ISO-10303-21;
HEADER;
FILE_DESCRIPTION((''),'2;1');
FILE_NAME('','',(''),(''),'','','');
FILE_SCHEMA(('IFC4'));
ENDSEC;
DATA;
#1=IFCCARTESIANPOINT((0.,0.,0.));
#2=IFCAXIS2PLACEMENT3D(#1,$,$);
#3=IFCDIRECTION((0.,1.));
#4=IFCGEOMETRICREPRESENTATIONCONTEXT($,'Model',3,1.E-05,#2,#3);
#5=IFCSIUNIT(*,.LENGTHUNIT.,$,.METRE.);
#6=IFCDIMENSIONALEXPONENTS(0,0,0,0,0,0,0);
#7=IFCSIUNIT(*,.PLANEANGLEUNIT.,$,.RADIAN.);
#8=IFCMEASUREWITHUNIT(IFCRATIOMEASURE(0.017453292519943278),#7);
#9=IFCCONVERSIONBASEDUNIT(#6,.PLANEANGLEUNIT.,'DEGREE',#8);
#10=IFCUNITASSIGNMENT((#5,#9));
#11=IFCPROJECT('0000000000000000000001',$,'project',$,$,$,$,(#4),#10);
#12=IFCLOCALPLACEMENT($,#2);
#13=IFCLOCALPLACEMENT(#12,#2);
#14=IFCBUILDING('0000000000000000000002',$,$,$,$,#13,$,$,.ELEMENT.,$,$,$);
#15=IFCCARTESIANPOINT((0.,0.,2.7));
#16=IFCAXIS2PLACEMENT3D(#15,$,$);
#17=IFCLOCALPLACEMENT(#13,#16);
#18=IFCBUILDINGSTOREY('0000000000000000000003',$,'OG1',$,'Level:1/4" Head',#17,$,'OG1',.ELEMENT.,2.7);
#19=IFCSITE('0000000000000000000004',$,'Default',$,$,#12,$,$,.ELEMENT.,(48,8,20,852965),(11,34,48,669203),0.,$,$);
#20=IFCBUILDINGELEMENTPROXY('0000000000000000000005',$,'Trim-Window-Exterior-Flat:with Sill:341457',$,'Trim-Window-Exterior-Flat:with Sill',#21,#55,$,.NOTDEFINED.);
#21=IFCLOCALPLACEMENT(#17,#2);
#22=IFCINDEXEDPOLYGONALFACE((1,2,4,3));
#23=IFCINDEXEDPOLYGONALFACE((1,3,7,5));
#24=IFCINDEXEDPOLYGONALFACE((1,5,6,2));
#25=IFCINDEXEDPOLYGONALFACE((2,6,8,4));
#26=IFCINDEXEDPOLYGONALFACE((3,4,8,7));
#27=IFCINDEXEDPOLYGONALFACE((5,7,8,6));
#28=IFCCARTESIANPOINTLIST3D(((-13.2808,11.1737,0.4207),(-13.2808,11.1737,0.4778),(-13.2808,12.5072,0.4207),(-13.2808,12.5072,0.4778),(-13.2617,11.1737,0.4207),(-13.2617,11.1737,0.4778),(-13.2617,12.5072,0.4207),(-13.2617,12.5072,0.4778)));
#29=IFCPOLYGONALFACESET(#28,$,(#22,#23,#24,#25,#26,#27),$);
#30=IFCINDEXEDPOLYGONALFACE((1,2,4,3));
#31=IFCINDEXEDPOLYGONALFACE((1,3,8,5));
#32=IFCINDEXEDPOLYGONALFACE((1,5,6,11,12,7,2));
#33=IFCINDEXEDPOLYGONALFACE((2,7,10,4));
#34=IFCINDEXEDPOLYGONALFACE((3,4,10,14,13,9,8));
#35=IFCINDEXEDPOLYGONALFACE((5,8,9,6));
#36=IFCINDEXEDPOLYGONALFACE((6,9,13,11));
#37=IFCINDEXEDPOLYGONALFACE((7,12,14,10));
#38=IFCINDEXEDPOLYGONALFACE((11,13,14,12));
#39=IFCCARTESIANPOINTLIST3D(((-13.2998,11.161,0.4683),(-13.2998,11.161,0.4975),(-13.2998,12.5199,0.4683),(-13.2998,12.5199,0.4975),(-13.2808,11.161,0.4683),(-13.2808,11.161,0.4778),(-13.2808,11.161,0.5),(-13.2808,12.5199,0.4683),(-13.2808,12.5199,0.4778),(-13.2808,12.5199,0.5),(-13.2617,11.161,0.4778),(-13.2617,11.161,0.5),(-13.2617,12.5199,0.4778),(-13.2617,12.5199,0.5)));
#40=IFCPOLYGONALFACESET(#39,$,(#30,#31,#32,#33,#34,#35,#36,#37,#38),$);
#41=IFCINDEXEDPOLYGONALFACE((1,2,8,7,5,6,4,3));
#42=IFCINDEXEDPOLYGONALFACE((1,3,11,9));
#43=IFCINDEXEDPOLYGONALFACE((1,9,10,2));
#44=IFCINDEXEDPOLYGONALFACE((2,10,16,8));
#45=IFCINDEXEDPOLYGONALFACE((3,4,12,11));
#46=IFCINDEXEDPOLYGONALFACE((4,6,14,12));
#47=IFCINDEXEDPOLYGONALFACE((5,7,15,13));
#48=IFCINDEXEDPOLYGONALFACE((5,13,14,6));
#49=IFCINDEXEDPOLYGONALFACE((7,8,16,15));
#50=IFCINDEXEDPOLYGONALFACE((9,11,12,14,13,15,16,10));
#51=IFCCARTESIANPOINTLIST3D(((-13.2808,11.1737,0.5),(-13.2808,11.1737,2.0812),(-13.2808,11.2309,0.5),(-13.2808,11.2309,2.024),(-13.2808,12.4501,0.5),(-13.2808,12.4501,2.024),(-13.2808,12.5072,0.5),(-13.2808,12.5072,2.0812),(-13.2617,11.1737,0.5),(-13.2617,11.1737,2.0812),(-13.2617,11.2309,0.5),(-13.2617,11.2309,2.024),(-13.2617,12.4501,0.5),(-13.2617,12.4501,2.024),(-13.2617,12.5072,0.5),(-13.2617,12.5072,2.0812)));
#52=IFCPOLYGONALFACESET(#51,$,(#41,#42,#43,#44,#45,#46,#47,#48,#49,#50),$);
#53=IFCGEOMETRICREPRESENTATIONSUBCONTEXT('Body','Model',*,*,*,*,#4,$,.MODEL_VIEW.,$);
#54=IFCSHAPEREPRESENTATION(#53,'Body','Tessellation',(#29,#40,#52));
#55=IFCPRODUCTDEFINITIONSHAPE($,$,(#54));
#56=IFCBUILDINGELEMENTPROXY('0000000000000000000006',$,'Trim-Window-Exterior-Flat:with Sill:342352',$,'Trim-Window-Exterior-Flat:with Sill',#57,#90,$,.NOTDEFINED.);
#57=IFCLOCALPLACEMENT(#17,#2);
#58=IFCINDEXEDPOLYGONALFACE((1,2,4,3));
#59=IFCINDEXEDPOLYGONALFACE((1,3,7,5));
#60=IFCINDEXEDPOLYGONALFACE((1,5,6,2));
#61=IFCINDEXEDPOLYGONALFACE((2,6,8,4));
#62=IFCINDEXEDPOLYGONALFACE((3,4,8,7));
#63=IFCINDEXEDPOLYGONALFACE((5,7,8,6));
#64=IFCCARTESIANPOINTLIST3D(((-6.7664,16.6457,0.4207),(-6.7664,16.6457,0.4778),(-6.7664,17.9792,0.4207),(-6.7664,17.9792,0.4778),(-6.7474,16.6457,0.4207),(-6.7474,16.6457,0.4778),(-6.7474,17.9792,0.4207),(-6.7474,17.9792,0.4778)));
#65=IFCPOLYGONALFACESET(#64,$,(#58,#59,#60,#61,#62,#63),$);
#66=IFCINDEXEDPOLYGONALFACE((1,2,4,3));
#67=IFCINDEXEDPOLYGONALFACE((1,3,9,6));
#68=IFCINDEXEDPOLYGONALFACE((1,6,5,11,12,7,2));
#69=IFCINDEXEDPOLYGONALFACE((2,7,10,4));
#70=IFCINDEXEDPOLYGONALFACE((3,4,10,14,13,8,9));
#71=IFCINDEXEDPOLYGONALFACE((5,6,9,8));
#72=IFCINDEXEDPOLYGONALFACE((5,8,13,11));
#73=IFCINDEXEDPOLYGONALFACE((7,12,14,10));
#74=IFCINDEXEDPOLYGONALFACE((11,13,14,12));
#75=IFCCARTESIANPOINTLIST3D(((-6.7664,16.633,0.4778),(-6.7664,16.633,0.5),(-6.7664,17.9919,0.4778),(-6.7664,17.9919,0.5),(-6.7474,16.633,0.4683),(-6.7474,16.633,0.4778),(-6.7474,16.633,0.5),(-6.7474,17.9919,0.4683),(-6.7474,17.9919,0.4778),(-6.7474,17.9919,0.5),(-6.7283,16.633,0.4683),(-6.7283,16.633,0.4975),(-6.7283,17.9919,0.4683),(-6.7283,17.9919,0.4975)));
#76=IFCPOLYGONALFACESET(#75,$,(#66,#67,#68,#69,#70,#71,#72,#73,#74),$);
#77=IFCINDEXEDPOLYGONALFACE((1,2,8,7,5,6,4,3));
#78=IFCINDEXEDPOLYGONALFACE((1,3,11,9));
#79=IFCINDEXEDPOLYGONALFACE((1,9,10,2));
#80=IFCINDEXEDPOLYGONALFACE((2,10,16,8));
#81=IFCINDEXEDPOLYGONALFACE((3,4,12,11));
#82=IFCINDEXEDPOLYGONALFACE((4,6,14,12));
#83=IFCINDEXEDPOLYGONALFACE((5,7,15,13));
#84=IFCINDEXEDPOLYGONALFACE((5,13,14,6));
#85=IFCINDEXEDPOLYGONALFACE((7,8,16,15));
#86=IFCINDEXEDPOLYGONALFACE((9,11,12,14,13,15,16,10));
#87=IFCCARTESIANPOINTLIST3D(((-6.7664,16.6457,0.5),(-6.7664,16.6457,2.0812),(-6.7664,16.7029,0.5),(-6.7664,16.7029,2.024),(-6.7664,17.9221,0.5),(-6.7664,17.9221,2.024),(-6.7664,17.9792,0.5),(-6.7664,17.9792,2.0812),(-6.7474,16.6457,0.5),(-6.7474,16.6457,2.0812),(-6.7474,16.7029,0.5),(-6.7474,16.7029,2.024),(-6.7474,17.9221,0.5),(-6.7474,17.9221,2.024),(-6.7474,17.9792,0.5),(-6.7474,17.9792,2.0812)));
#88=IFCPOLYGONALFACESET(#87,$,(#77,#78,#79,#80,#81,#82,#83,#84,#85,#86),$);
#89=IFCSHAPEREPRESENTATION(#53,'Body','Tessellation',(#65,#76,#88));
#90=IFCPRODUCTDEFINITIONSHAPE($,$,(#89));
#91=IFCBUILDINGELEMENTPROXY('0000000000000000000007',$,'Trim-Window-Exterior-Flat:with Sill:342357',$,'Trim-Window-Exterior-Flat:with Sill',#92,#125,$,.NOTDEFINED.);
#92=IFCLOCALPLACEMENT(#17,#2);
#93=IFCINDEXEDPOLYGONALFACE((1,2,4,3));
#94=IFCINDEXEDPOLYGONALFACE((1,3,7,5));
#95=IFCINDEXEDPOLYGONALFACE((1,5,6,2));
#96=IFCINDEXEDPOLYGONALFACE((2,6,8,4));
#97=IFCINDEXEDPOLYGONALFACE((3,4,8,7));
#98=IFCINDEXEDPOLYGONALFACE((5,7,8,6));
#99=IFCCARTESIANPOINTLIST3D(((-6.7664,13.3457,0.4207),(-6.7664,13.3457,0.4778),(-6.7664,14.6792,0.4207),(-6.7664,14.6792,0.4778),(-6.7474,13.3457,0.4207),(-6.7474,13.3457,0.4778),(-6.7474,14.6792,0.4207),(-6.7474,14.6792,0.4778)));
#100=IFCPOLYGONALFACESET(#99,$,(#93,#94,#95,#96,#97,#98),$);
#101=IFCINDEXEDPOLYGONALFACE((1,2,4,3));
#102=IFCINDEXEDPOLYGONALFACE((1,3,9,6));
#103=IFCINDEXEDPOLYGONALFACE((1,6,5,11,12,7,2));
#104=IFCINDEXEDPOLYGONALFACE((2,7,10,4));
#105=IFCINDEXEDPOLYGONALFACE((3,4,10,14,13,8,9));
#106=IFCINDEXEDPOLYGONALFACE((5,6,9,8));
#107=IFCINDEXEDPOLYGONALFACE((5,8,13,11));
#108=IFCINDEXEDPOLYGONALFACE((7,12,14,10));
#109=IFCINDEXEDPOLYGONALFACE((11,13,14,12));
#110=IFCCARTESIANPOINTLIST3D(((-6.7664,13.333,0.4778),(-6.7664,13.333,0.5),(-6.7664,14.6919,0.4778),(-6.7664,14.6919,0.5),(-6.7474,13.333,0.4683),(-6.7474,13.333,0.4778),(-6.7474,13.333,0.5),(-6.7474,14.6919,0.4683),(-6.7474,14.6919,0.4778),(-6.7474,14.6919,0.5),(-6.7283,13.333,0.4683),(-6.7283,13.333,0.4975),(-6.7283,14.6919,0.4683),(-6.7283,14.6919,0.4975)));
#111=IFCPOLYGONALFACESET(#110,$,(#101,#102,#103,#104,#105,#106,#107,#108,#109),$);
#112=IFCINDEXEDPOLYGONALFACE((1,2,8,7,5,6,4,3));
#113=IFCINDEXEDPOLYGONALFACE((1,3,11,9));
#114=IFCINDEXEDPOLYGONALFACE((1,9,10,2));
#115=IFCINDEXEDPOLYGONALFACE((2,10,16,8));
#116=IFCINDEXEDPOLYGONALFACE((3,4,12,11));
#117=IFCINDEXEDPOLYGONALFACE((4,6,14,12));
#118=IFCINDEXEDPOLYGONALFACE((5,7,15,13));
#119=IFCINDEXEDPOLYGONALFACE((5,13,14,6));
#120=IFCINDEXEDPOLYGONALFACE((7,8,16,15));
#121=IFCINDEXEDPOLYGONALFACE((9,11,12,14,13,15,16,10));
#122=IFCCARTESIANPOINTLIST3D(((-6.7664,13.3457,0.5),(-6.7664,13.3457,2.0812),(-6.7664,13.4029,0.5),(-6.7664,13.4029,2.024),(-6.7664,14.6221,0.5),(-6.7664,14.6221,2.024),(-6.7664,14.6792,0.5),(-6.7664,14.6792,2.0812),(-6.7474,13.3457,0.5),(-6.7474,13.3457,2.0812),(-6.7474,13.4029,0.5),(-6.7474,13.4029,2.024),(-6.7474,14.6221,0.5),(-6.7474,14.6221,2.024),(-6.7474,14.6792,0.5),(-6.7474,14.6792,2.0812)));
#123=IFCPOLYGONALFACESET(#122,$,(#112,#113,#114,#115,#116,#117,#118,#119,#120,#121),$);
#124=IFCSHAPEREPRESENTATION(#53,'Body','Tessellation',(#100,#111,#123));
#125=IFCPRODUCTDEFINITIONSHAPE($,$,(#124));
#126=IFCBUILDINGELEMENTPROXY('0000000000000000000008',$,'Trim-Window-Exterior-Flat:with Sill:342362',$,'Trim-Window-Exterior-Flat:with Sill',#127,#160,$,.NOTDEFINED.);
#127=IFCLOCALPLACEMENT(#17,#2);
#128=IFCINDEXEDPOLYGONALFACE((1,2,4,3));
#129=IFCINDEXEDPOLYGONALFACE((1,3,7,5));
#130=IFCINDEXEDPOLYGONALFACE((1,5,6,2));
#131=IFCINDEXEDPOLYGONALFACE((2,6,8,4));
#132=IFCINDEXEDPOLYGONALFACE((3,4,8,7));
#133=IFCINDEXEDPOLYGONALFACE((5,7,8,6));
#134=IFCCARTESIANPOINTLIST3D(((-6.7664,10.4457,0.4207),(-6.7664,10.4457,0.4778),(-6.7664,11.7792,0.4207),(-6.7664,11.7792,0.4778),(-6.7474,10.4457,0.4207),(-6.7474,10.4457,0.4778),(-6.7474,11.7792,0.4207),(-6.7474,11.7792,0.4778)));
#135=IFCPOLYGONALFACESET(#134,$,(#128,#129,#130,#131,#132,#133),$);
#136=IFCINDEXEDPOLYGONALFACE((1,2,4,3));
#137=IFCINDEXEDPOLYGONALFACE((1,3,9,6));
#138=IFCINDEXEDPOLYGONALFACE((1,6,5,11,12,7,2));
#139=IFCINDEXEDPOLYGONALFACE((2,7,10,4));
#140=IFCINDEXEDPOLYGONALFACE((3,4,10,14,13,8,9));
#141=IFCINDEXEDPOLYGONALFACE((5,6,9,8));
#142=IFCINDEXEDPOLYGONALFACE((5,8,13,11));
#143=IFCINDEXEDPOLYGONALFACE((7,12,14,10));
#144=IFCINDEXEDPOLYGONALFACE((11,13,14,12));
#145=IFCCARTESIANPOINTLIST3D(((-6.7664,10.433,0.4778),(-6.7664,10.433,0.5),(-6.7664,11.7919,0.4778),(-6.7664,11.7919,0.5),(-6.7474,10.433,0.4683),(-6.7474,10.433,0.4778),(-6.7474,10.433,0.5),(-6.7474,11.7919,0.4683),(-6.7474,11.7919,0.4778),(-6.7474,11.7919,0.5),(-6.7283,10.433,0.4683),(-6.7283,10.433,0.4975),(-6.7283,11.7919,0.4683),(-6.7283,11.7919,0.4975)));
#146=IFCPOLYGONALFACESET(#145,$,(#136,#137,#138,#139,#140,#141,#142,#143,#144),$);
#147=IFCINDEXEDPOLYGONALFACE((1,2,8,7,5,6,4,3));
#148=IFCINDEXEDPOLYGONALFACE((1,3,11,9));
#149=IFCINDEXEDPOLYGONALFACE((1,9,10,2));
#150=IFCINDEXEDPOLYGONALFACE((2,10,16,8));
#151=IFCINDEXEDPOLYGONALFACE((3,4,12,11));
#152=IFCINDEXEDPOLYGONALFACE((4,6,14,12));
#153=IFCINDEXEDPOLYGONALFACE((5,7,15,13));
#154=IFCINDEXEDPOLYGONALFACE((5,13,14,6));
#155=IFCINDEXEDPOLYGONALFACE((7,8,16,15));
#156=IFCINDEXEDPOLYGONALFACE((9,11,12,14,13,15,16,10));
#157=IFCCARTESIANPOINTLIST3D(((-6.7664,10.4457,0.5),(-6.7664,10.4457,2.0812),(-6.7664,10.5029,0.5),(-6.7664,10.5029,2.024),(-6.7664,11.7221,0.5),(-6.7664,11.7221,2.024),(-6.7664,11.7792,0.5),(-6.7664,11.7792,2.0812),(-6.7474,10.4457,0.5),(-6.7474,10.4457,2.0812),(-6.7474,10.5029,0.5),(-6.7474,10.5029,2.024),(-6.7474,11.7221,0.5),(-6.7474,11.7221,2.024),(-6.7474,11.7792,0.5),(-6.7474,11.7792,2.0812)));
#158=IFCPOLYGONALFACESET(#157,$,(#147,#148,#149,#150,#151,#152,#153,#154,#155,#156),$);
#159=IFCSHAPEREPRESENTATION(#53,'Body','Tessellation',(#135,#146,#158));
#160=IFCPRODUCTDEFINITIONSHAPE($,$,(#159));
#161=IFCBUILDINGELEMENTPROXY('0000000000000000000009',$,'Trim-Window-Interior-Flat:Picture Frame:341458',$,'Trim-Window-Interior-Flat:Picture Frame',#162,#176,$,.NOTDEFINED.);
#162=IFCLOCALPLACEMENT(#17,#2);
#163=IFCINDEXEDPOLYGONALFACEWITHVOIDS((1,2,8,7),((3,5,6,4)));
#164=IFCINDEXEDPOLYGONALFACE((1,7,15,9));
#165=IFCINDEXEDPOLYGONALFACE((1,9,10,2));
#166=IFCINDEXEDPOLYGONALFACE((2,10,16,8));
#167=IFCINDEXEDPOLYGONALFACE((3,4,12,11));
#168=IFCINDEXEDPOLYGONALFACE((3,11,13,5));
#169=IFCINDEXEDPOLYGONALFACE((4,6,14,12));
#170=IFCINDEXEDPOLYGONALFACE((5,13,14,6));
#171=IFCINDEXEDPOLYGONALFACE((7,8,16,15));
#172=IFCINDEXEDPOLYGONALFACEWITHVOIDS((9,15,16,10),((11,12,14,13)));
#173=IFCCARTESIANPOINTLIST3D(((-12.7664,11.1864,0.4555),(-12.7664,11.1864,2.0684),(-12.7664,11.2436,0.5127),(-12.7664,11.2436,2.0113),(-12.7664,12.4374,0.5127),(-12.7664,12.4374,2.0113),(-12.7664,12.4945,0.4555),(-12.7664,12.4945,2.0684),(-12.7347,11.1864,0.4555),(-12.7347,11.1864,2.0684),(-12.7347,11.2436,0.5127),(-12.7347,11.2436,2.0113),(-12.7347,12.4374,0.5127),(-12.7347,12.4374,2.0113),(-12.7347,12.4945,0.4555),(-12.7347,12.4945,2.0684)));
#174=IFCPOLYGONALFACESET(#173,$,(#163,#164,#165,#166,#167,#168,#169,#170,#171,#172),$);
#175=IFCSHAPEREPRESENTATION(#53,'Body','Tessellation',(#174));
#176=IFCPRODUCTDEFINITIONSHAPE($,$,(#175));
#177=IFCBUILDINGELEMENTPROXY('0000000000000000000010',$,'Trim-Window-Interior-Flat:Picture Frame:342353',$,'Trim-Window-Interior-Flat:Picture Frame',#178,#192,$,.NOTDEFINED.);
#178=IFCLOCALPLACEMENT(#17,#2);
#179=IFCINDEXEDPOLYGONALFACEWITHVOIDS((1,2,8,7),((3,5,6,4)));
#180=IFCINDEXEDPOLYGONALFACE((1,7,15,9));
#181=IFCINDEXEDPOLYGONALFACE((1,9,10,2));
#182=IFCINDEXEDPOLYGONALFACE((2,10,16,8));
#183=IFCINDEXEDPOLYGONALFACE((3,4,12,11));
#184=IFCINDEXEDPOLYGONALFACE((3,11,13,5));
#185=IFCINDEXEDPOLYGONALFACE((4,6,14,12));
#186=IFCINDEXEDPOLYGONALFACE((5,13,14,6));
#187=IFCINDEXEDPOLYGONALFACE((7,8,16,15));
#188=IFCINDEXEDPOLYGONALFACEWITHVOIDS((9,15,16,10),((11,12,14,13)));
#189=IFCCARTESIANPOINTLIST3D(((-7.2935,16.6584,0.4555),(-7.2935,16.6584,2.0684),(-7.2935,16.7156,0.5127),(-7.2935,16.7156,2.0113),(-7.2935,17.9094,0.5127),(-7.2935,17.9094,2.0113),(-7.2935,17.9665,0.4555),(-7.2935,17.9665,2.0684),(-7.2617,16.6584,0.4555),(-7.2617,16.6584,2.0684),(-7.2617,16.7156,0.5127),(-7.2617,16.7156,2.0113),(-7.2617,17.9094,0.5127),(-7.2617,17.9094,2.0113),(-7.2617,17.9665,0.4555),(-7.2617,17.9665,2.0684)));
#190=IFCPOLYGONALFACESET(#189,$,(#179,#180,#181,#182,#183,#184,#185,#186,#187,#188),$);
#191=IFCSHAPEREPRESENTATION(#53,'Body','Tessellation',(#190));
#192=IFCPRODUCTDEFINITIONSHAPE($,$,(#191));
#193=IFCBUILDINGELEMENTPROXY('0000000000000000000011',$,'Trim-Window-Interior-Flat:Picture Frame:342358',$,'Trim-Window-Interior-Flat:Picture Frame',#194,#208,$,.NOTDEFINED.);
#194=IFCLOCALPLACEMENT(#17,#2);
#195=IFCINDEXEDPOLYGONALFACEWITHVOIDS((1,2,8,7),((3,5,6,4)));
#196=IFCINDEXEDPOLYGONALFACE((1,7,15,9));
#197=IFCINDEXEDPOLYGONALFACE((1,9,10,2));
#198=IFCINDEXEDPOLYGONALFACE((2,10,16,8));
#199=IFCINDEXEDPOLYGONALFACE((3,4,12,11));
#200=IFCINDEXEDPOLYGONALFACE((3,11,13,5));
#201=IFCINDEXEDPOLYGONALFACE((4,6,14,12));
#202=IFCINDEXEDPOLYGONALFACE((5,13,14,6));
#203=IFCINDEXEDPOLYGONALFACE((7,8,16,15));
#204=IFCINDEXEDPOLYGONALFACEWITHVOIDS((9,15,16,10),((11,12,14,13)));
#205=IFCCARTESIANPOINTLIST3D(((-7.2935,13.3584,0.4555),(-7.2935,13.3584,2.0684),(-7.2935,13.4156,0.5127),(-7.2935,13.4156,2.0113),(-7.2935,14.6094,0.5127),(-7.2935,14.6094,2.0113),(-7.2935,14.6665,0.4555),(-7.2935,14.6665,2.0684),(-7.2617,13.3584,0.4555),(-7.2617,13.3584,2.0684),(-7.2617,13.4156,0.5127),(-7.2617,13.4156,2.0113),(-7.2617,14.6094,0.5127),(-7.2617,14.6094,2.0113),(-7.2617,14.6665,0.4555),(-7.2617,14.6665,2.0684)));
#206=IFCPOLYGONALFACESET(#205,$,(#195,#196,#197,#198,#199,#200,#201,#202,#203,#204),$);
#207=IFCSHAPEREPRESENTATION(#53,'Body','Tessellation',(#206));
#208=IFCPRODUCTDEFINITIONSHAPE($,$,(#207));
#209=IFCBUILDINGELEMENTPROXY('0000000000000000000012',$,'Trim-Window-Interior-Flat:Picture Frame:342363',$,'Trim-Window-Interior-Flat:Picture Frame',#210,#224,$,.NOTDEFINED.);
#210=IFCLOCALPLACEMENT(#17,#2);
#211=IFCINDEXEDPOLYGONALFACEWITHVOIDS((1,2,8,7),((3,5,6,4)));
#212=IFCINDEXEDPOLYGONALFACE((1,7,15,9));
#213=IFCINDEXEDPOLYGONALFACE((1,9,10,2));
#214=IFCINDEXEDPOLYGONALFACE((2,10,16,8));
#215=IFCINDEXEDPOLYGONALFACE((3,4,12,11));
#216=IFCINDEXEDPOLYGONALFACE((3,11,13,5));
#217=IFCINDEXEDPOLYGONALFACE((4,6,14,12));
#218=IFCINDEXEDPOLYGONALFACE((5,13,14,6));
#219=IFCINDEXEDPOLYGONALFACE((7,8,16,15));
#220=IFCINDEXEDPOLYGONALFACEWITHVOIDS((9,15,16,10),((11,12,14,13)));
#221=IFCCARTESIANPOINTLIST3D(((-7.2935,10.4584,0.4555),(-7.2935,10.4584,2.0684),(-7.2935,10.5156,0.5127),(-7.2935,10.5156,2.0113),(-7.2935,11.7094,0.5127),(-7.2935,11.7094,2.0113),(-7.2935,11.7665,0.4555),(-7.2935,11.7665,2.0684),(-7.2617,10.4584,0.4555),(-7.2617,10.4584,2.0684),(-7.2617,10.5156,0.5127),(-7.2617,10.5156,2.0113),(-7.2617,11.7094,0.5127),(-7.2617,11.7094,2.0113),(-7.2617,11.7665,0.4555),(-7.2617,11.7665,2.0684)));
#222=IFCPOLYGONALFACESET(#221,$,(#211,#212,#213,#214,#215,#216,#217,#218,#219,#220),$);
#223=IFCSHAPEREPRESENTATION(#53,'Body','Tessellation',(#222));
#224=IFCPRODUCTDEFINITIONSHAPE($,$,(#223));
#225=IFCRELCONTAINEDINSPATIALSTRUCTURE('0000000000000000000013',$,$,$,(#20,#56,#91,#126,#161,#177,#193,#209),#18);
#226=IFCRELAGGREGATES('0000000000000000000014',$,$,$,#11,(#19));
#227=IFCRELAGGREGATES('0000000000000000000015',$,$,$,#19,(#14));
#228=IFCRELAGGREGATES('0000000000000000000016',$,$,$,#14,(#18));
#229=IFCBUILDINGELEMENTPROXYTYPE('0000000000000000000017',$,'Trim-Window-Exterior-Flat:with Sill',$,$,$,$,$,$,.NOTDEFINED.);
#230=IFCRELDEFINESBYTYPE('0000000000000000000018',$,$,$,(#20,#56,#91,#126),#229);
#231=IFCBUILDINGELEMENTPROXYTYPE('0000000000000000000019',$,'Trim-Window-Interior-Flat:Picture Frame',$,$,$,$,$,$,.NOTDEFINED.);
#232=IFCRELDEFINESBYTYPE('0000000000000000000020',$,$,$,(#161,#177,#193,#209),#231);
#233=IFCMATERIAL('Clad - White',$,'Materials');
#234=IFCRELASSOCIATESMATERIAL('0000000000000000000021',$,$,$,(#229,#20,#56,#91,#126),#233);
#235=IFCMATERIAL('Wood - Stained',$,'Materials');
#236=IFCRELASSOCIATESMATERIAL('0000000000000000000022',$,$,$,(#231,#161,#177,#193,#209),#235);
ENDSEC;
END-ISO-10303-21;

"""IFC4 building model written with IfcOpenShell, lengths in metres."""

from ifc_helpers import new_model, entity, si_unit, converted_unit, direction, frame, origin, place, context, subcontext, project, spatial, indexed_curve, outline, extrude, source, transform, mapped, material, type_object, type_shapes, element, save


model = new_model("IFC4")

# Units and contexts
model_context = context("Model", 3, precision=1e-05, world=origin(), true_north=direction((0.0, 1.0)))
body_context = subcontext(model_context, "Body", "Model", "MODEL_VIEW")
ifc_project = project(units=[si_unit("LENGTHUNIT", "METRE"), converted_unit("PLANEANGLEUNIT", "DEGREE", entity("IfcRatioMeasure", 0.017453292519943278), si_unit("PLANEANGLEUNIT", "RADIAN"), dimensions=[0, 0, 0, 0, 0, 0, 0])], contexts=[model_context])

# Site, building, storey
site_placement = place(None, origin())
site = spatial("IfcSite", under=ifc_project, at=site_placement, Name="Default", CompositionType="ELEMENT", RefLatitude=(48, 8, 20, 852965), RefLongitude=(11, 34, 48, 669203), RefElevation=0.0)
building_placement = place(site_placement, origin())
building = spatial("IfcBuilding", under=site, at=building_placement, CompositionType="ELEMENT")
storey_placement = place(building_placement, frame((0.0, 0.0, 2.7)))
storey = spatial("IfcBuildingStorey", under=building, at=storey_placement, Name="OG1", ObjectType="Level:1/4\" Head", LongName="OG1", CompositionType="ELEMENT", Elevation=2.7)

# Building element proxies
ifc_material_1 = material(Name="Clad - White", Category="Materials")
ifc_material_2 = material(Name="Wood - Stained", Category="Materials")
building_element_proxy_type_1 = type_object("IfcBuildingElementProxyType", Name="Trim-Window-Exterior-Flat:with Sill", PredefinedType="NOTDEFINED", material=ifc_material_1)
shared_shape_1 = source(origin(), body_context, "Body", "SweptSolid", [
    extrude(outline(indexed_curve([(-0.6667, -0.0286), (0.6667, -0.0286), (0.6667, 0.0286), (-0.6667, 0.0286), (-0.6667, -0.0286)], self_intersect=False)), frame((0.0, -1.5748, 0.0), z_axis=(0.0, 0.0, 1.0), x_axis=(-1.0, 0.0, 0.0)), (0.0, 0.0, 1.0), 0.019),
    extrude(outline(indexed_curve([(-0.019, -0.016), (0.0, -0.016), (0.0, -0.0064), (0.019, -0.0064), (0.019, 0.0158), (0.0, 0.0158), (-0.019, 0.0133), (-0.019, -0.016)], self_intersect=False)), frame((-0.6794, -1.5398, 0.019), z_axis=(1.0, 0.0, 0.0), x_axis=(0.0, 0.0, -1.0)), (0.0, 0.0, 1.0), 1.3589),
    extrude(outline(indexed_curve([(-0.8049, -0.6667), (0.7763, -0.6667), (0.7763, -0.6096), (-0.7477, -0.6096), (-0.7477, 0.6096), (0.7763, 0.6096), (0.7763, 0.6667), (-0.8049, 0.6667), (-0.8049, -0.6667)], self_intersect=False)), frame((0.0, -0.7477, 0.0), z_axis=(0.0, 0.0, 1.0), x_axis=(0.0, -1.0, 0.0)), (0.0, 0.0, 1.0), 0.019),
])
type_shapes(building_element_proxy_type_1, [shared_shape_1])
for number, where, z_axis, x_axis, name in (
    (1, (-13.2617, 11.8405, 2.024), (-1.0, 0.0, 0.0), (0.0, -1.0, 0.0), "Trim-Window-Exterior-Flat:with Sill:341457"),
    (2, (-6.7664, 17.3125, 2.024), (1.0, 0.0, 0.0), (0.0, 1.0, 0.0), "Trim-Window-Exterior-Flat:with Sill:342352"),
    (3, (-6.7664, 14.0125, 2.024), (1.0, 0.0, 0.0), (0.0, 1.0, 0.0), "Trim-Window-Exterior-Flat:with Sill:342357"),
    (4, (-6.7664, 11.1125, 2.024), (1.0, 0.0, 0.0), (0.0, 1.0, 0.0), "Trim-Window-Exterior-Flat:with Sill:342362"),
):
    element("IfcBuildingElementProxy", number, at=place(storey_placement, frame(where, z_axis=z_axis, x_axis=x_axis)), inside=storey, type_object=building_element_proxy_type_1, material=ifc_material_1, Name=name, ObjectType="Trim-Window-Exterior-Flat:with Sill", PredefinedType="NOTDEFINED", context=body_context, shape_type="MappedRepresentation", body=[
        mapped(shared_shape_1, transform((0.0, 0.0, 0.0), scale=1.0)),
    ])
building_element_proxy_type_2 = type_object("IfcBuildingElementProxyType", Name="Trim-Window-Interior-Flat:Picture Frame", PredefinedType="NOTDEFINED", material=ifc_material_2)
shared_shape_2 = source(origin(), body_context, "Body", "SweptSolid", [
    extrude(outline(indexed_curve([(-0.654, -0.8064), (0.654, -0.8064), (0.654, 0.8064), (-0.654, 0.8064), (-0.654, -0.8064)], self_intersect=False), holes=[indexed_curve([(-0.5969, -0.7493), (-0.5969, 0.7493), (0.5969, 0.7493), (0.5969, -0.7493), (-0.5969, -0.7493)], self_intersect=False)]), frame((0.0, -0.762, 0.0), z_axis=(0.0, 0.0, 1.0), x_axis=(-1.0, 0.0, 0.0)), (0.0, 0.0, 1.0), 0.0317),
])
type_shapes(building_element_proxy_type_2, [shared_shape_2])
for number, where, z_axis, x_axis, name in (
    (5, (-12.7664, 11.8405, 2.024), (1.0, 0.0, 0.0), (0.0, 1.0, 0.0), "Trim-Window-Interior-Flat:Picture Frame:341458"),
    (6, (-7.2617, 17.3125, 2.024), (-1.0, 0.0, 0.0), (0.0, -1.0, 0.0), "Trim-Window-Interior-Flat:Picture Frame:342353"),
    (7, (-7.2617, 14.0125, 2.024), (-1.0, 0.0, 0.0), (0.0, -1.0, 0.0), "Trim-Window-Interior-Flat:Picture Frame:342358"),
    (8, (-7.2617, 11.1125, 2.024), (-1.0, 0.0, 0.0), (0.0, -1.0, 0.0), "Trim-Window-Interior-Flat:Picture Frame:342363"),
):
    element("IfcBuildingElementProxy", number, at=place(storey_placement, frame(where, z_axis=z_axis, x_axis=x_axis)), inside=storey, type_object=building_element_proxy_type_2, material=ifc_material_2, Name=name, ObjectType="Trim-Window-Interior-Flat:Picture Frame", PredefinedType="NOTDEFINED", context=body_context, shape_type="MappedRepresentation", body=[
        mapped(shared_shape_2, transform((0.0, 0.0, 0.0), scale=1.0)),
    ])

save(model, "model.ifc")
